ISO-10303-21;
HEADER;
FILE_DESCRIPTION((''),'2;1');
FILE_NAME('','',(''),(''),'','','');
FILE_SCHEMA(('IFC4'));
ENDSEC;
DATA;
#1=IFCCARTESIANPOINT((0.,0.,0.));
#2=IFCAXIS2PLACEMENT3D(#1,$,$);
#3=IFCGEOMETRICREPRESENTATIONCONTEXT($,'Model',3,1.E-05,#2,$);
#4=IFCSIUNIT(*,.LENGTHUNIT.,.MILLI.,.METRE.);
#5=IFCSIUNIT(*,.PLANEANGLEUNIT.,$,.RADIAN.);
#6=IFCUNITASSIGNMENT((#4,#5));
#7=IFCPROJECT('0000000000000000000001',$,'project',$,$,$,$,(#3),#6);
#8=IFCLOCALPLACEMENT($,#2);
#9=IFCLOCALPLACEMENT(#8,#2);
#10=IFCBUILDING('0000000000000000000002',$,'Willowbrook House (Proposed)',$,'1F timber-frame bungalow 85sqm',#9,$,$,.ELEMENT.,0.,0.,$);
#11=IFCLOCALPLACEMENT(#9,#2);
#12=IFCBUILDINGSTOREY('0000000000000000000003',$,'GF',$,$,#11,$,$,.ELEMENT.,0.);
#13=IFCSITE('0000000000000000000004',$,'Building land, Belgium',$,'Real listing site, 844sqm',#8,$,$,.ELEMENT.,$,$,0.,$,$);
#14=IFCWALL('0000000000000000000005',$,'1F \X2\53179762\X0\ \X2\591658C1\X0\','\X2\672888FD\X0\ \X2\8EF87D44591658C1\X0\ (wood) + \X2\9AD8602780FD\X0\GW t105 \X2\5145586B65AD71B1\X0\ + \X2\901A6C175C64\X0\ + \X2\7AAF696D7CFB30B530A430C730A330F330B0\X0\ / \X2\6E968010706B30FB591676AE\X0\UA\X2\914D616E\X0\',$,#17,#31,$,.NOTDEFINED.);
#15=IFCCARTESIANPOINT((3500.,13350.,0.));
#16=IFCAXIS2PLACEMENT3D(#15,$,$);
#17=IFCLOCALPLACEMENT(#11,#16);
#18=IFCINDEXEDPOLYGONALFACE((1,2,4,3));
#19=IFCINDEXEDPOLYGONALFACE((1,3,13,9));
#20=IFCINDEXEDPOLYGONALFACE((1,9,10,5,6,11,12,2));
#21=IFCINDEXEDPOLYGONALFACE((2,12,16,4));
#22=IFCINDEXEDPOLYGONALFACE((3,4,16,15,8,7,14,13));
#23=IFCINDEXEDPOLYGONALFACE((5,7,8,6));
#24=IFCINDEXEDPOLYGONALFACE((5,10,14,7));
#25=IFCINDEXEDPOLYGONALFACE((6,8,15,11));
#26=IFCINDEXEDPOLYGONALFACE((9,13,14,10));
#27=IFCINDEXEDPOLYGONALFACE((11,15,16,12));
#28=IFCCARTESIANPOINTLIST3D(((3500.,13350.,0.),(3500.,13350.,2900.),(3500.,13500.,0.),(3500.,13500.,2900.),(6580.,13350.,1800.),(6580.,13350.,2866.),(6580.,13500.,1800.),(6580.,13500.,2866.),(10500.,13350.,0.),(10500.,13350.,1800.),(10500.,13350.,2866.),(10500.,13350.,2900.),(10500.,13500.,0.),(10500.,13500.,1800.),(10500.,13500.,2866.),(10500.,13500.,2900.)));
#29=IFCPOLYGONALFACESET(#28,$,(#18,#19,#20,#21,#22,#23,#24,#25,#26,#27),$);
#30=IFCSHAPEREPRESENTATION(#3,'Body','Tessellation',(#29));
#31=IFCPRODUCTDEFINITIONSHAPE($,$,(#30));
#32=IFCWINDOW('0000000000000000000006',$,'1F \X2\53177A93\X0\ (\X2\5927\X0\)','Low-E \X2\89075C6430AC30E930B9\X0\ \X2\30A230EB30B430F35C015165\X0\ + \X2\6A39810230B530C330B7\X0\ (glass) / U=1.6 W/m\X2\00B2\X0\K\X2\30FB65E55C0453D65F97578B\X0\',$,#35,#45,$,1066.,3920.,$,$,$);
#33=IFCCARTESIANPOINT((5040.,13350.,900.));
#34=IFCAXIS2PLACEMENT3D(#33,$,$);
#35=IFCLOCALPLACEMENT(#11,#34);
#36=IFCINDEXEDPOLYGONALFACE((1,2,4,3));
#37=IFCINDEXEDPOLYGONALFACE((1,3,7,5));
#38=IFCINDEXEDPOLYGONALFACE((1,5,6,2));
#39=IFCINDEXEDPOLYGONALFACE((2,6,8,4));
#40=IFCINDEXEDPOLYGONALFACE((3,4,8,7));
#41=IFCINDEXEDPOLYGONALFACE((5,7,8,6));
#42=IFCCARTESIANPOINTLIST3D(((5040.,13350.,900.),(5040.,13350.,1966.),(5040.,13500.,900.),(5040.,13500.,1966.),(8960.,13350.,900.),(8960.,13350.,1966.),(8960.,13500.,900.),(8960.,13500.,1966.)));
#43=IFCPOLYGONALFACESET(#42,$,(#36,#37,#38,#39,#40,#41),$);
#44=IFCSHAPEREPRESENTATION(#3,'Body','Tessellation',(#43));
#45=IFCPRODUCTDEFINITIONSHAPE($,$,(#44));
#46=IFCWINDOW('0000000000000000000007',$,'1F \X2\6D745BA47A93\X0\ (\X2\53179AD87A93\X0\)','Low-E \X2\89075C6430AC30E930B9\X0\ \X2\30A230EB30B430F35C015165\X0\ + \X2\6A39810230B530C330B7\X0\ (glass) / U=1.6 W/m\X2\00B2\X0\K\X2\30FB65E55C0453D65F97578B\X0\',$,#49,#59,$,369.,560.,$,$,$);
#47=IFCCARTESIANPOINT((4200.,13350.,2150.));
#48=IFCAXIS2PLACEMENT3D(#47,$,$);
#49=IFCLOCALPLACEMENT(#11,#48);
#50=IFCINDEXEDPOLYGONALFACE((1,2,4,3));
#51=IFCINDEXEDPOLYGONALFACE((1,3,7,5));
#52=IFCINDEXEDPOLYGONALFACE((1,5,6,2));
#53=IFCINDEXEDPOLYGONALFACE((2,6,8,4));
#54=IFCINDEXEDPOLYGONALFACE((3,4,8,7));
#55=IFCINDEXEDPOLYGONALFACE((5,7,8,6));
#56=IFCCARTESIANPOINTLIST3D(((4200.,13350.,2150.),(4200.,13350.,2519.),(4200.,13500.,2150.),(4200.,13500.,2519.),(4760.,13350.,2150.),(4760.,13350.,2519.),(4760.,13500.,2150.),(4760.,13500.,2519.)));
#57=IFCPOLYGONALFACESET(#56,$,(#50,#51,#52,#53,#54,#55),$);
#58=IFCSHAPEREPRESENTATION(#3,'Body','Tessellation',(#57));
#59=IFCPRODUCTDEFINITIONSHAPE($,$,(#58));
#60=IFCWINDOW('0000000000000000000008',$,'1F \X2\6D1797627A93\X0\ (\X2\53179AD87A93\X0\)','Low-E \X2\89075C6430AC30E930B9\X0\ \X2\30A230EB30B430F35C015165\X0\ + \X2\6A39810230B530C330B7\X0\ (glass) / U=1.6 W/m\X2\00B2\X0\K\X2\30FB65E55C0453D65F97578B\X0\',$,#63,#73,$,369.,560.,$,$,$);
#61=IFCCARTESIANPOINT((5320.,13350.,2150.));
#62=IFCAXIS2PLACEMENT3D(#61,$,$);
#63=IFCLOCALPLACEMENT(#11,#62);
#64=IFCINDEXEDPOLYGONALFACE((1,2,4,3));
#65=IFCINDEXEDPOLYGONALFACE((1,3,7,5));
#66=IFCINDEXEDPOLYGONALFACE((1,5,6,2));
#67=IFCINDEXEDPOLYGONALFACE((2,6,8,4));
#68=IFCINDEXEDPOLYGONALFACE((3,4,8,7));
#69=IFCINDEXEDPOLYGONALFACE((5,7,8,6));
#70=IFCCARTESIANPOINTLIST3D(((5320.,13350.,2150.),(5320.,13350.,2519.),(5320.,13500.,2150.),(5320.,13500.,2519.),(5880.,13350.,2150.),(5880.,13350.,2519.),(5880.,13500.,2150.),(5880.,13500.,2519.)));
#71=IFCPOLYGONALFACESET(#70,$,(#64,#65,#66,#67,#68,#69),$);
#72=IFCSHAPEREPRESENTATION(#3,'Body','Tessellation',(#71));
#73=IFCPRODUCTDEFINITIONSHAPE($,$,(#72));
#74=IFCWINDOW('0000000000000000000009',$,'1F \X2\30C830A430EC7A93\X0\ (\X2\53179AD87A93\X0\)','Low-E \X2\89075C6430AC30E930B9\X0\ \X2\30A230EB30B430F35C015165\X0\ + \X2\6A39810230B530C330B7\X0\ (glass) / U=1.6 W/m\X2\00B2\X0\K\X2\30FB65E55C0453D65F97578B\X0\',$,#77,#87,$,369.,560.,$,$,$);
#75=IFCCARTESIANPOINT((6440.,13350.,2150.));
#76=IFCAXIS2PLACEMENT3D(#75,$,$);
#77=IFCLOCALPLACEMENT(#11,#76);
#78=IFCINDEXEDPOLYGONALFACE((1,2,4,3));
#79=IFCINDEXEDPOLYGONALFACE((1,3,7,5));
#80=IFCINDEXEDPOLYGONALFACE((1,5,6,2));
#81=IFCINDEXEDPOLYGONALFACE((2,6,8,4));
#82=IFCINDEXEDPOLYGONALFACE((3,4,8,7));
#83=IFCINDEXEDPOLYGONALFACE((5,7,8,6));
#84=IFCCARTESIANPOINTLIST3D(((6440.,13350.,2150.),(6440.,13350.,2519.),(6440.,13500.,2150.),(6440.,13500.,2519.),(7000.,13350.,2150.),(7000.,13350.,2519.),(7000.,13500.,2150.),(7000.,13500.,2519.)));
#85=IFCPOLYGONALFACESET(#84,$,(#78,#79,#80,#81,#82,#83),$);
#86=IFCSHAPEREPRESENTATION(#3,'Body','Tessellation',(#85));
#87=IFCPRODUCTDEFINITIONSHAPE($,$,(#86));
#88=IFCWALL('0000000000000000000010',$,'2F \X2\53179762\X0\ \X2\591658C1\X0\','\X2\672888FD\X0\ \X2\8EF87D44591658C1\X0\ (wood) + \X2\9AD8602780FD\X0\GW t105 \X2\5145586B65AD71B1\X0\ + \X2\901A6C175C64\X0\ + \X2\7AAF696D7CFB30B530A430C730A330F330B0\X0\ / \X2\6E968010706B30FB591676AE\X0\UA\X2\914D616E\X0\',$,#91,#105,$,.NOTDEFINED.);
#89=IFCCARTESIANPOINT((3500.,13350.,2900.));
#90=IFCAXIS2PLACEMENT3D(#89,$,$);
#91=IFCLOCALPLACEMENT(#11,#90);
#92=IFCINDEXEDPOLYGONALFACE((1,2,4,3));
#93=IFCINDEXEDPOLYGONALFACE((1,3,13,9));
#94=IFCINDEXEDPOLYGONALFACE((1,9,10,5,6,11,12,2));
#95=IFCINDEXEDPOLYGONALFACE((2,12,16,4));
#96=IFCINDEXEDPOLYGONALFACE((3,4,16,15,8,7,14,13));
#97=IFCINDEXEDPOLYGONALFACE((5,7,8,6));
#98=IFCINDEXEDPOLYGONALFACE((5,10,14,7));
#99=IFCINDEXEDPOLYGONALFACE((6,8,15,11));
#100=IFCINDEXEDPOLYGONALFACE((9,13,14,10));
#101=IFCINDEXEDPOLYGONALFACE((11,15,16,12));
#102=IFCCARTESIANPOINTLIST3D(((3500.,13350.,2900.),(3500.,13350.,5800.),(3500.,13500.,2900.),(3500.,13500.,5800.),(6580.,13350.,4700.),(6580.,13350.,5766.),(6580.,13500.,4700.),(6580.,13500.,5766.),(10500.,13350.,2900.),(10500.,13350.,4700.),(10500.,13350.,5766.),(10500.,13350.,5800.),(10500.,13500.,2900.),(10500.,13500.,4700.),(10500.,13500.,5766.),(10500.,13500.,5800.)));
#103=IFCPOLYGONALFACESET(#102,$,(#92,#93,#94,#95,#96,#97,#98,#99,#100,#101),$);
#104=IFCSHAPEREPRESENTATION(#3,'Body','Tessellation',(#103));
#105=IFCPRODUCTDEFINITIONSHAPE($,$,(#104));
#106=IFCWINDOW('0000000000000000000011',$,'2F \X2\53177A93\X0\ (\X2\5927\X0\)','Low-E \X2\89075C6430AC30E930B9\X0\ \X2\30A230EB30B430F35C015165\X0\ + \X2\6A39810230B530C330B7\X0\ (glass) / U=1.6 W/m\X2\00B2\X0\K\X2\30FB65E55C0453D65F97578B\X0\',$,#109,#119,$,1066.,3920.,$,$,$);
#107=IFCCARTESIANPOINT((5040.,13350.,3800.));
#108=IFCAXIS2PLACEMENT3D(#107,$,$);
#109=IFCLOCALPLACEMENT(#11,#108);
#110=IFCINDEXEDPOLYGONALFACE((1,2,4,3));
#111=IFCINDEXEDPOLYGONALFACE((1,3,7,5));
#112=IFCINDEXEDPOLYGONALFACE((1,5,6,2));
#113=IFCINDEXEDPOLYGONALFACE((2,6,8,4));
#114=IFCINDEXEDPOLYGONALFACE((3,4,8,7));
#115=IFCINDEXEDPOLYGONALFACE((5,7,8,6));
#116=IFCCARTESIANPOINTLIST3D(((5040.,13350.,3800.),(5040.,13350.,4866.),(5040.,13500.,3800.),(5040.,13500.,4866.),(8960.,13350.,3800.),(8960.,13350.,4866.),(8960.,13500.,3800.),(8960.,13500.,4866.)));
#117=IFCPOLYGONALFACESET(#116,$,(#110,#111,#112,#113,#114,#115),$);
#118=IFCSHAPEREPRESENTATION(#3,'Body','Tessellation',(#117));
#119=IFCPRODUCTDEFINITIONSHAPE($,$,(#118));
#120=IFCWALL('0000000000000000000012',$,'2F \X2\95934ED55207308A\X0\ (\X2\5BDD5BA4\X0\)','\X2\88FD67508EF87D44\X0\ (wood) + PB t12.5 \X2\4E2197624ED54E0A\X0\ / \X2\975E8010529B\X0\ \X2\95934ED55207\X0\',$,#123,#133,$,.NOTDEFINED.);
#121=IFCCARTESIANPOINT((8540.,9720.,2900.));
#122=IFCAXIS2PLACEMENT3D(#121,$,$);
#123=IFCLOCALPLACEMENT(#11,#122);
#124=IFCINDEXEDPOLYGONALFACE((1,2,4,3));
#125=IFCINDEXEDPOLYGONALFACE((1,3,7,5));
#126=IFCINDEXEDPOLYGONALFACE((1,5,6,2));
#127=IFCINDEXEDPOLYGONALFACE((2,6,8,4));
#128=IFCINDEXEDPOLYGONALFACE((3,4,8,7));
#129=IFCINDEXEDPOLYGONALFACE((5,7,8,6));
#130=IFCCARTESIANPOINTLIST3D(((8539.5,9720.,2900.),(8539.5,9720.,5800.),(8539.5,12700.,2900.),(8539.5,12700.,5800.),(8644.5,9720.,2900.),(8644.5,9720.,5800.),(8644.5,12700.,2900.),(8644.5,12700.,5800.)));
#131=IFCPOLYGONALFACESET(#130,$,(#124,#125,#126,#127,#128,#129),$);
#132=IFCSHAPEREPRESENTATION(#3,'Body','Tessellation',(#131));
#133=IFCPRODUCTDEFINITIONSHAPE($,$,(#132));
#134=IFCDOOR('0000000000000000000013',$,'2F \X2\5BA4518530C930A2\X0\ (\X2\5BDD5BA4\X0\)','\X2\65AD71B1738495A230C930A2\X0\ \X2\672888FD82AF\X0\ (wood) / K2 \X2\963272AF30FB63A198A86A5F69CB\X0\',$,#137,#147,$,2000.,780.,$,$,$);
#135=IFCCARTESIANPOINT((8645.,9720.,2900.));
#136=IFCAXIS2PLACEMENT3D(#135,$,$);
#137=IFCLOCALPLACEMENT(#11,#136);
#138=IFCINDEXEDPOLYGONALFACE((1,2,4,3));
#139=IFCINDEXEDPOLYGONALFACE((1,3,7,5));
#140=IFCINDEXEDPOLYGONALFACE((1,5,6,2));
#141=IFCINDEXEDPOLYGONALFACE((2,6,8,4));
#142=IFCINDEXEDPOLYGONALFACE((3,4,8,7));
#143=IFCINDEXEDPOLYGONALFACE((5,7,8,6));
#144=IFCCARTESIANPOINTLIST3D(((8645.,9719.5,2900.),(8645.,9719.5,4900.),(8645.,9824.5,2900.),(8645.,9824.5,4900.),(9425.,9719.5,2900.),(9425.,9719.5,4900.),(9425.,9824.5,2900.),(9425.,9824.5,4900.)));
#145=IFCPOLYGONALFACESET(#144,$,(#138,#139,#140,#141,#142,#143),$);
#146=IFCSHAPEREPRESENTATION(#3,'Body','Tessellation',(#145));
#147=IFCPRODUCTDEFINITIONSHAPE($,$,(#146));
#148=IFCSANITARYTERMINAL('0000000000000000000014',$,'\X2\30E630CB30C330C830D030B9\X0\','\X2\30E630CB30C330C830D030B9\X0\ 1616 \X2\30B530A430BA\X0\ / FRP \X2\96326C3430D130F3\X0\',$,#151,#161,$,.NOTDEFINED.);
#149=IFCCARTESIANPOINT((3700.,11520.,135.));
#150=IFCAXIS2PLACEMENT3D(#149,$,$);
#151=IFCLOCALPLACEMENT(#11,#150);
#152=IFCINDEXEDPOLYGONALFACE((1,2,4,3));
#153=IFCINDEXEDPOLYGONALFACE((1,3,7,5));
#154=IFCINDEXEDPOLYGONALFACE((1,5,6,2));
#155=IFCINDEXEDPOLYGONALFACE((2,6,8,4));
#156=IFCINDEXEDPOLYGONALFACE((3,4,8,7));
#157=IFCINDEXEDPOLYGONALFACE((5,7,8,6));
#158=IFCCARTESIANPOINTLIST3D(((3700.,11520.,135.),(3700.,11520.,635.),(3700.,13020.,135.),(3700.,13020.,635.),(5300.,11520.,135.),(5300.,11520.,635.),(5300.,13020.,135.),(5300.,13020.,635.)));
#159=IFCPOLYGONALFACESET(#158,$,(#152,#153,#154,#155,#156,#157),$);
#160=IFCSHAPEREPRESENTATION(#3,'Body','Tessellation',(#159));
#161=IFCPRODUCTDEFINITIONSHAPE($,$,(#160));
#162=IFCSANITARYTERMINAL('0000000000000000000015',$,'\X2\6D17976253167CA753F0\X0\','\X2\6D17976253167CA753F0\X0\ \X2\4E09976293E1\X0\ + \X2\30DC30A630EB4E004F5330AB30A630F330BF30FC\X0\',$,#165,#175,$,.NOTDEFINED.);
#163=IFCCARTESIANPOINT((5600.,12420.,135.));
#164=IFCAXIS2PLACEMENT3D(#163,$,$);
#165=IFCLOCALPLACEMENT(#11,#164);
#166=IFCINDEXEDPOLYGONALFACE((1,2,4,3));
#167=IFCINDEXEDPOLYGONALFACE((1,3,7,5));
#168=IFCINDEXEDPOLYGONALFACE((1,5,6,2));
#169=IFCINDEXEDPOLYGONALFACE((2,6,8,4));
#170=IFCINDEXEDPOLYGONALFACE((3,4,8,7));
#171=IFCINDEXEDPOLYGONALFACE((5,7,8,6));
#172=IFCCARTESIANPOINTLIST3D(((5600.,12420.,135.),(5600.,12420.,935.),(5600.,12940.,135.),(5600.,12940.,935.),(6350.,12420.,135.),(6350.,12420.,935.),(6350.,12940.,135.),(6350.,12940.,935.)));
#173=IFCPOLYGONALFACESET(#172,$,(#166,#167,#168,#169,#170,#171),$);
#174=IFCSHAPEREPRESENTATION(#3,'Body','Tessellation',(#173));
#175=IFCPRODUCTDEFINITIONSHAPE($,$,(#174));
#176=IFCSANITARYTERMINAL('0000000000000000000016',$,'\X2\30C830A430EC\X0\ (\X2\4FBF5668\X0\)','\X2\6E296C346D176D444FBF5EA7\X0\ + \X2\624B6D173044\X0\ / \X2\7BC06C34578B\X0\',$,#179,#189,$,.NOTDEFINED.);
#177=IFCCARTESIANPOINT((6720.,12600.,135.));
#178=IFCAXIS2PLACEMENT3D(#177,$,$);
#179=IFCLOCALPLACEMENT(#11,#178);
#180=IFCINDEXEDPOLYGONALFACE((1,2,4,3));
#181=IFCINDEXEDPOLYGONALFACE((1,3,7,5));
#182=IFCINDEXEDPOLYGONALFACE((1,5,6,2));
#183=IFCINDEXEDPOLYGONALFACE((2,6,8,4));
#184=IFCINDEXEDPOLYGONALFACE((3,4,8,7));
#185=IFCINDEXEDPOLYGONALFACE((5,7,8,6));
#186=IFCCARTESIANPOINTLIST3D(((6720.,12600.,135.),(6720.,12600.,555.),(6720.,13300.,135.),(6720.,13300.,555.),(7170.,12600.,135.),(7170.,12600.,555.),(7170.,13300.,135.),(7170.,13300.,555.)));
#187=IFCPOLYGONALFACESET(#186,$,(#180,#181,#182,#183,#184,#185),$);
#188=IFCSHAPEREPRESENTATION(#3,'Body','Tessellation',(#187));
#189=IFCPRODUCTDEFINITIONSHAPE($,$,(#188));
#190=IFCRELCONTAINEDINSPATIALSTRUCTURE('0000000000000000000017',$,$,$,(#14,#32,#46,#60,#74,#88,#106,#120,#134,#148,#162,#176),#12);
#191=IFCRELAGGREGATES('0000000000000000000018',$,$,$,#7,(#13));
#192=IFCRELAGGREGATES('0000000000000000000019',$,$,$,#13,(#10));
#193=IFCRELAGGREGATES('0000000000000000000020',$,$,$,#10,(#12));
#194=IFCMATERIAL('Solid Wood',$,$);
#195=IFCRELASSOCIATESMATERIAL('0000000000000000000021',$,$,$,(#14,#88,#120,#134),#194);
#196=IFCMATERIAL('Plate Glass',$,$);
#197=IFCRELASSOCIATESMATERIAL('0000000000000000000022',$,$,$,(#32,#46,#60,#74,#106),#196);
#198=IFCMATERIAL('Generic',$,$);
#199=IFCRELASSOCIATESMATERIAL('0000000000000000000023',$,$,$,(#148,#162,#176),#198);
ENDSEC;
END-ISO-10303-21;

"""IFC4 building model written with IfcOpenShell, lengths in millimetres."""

from ifc_helpers import new_model, si_unit, frame, frame_2d, origin, place, context, project, spatial, rectangle, extrude, material, element, fill, save


model = new_model("IFC4")

# Units and contexts
model_context = context("Model", 3, precision=1e-05, world=origin())
ifc_project = project(units=[si_unit("LENGTHUNIT", "METRE", prefix="MILLI"), si_unit("PLANEANGLEUNIT", "RADIAN")], contexts=[model_context])

# Site, building, storey
site_placement = place(None, origin())
site = spatial("IfcSite", under=ifc_project, at=site_placement, Name="Building land, Belgium", ObjectType="Real listing site, 844sqm", CompositionType="ELEMENT", RefElevation=0.0)
building_placement = place(site_placement, origin())
building = spatial("IfcBuilding", under=site, at=building_placement, Name="Willowbrook House (Proposed)", ObjectType="1F timber-frame bungalow 85sqm", CompositionType="ELEMENT", ElevationOfRefHeight=0.0, ElevationOfTerrain=0.0)
storey_placement = place(building_placement, origin())
storey = spatial("IfcBuildingStorey", under=building, at=storey_placement, Name="GF", CompositionType="ELEMENT", Elevation=0.0)

# Wall, openings, windows
ifc_material_1 = material(Name="Solid Wood")
wall_1_placement = place(storey_placement, frame((3500.0, 13350.0, 0.0)))
wall_1 = element("IfcWall", 1, at=wall_1_placement, inside=storey, material=ifc_material_1, Name="1F 北面 外壁", Description="木製 軸組外壁 (wood) + 高性能GW t105 充填断熱 + 通気層 + 窯業系サイディング / 準耐火・外皮UA配慮", PredefinedType="NOTDEFINED", context=model_context, shape_type="SweptSolid", body=[
    extrude(rectangle(XDim=7000.0, YDim=150.0, at=frame_2d((3500.0, 75.0))), frame((3500.0, 13350.0, 0.0)), (0.0, 0.0, 1.0), 2900.0),
])
opening_1_placement = place(storey_placement, frame((5040.0, 13350.0, 900.0)))
opening_1 = element("IfcOpeningElement", 2, at=opening_1_placement, cuts=wall_1, PredefinedType="NOTDEFINED", context=model_context, shape_type="SweptSolid", body=[
    extrude(rectangle(XDim=3920.0, YDim=150.0, at=frame_2d((1960.0, 75.0))), frame((5040.0, 13350.0, 900.0)), (0.0, 0.0, 1.0), 1066.0),
])
opening_2_placement = place(storey_placement, frame((4200.0, 13350.0, 2150.0)))
opening_2 = element("IfcOpeningElement", 3, at=opening_2_placement, cuts=wall_1, PredefinedType="NOTDEFINED", context=model_context, shape_type="SweptSolid", body=[
    extrude(rectangle(XDim=560.0, YDim=150.0, at=frame_2d((280.0, 75.0))), frame((4200.0, 13350.0, 2150.0)), (0.0, 0.0, 1.0), 369.0),
])
opening_3_placement = place(storey_placement, frame((5320.0, 13350.0, 2150.0)))
opening_3 = element("IfcOpeningElement", 4, at=opening_3_placement, cuts=wall_1, PredefinedType="NOTDEFINED", context=model_context, shape_type="SweptSolid", body=[
    extrude(rectangle(XDim=560.0, YDim=150.0, at=frame_2d((280.0, 75.0))), frame((5320.0, 13350.0, 2150.0)), (0.0, 0.0, 1.0), 369.0),
])
opening_4_placement = place(storey_placement, frame((6440.0, 13350.0, 2150.0)))
opening_4 = element("IfcOpeningElement", 5, at=opening_4_placement, cuts=wall_1, PredefinedType="NOTDEFINED", context=model_context, shape_type="SweptSolid", body=[
    extrude(rectangle(XDim=560.0, YDim=150.0, at=frame_2d((280.0, 75.0))), frame((6440.0, 13350.0, 2150.0)), (0.0, 0.0, 1.0), 369.0),
])
ifc_material_2 = material(Name="Plate Glass")
window_1_placement = place(storey_placement, frame((5040.0, 13350.0, 900.0)))
window_1 = element("IfcWindow", 6, at=window_1_placement, inside=storey, material=ifc_material_2, Name="1F 北窓 (大)", Description="Low-E 複層ガラス アルゴン封入 + 樹脂サッシ (glass) / U=1.6 W/m²K・日射取得型", OverallHeight=1066.0, OverallWidth=3920.0, context=model_context, shape_type="SweptSolid", body=[
    extrude(rectangle(XDim=3920.0, YDim=150.0, at=frame_2d((1960.0, 75.0))), frame((5040.0, 13350.0, 900.0)), (0.0, 0.0, 1.0), 1066.0),
])
fill(opening_1, window_1)
window_2_placement = place(storey_placement, frame((4200.0, 13350.0, 2150.0)))
window_2 = element("IfcWindow", 7, at=window_2_placement, inside=storey, material=ifc_material_2, Name="1F 浴室窓 (北高窓)", Description="Low-E 複層ガラス アルゴン封入 + 樹脂サッシ (glass) / U=1.6 W/m²K・日射取得型", OverallHeight=369.0, OverallWidth=560.0, context=model_context, shape_type="SweptSolid", body=[
    extrude(rectangle(XDim=560.0, YDim=150.0, at=frame_2d((280.0, 75.0))), frame((4200.0, 13350.0, 2150.0)), (0.0, 0.0, 1.0), 369.0),
])
fill(opening_2, window_2)
window_3_placement = place(storey_placement, frame((5320.0, 13350.0, 2150.0)))
window_3 = element("IfcWindow", 8, at=window_3_placement, inside=storey, material=ifc_material_2, Name="1F 洗面窓 (北高窓)", Description="Low-E 複層ガラス アルゴン封入 + 樹脂サッシ (glass) / U=1.6 W/m²K・日射取得型", OverallHeight=369.0, OverallWidth=560.0, context=model_context, shape_type="SweptSolid", body=[
    extrude(rectangle(XDim=560.0, YDim=150.0, at=frame_2d((280.0, 75.0))), frame((5320.0, 13350.0, 2150.0)), (0.0, 0.0, 1.0), 369.0),
])
fill(opening_3, window_3)
window_4_placement = place(storey_placement, frame((6440.0, 13350.0, 2150.0)))
window_4 = element("IfcWindow", 9, at=window_4_placement, inside=storey, material=ifc_material_2, Name="1F トイレ窓 (北高窓)", Description="Low-E 複層ガラス アルゴン封入 + 樹脂サッシ (glass) / U=1.6 W/m²K・日射取得型", OverallHeight=369.0, OverallWidth=560.0, context=model_context, shape_type="SweptSolid", body=[
    extrude(rectangle(XDim=560.0, YDim=150.0, at=frame_2d((280.0, 75.0))), frame((6440.0, 13350.0, 2150.0)), (0.0, 0.0, 1.0), 369.0),
])
fill(opening_4, window_4)

# Wall, opening, window
wall_2_placement = place(storey_placement, frame((3500.0, 13350.0, 2900.0)))
wall_2 = element("IfcWall", 10, at=wall_2_placement, inside=storey, material=ifc_material_1, Name="2F 北面 外壁", Description="木製 軸組外壁 (wood) + 高性能GW t105 充填断熱 + 通気層 + 窯業系サイディング / 準耐火・外皮UA配慮", PredefinedType="NOTDEFINED", context=model_context, shape_type="SweptSolid", body=[
    extrude(rectangle(XDim=7000.0, YDim=150.0, at=frame_2d((3500.0, 75.0))), frame((3500.0, 13350.0, 2900.0)), (0.0, 0.0, 1.0), 2900.0),
])
opening_5_placement = place(storey_placement, frame((5040.0, 13350.0, 3800.0)))
opening_5 = element("IfcOpeningElement", 11, at=opening_5_placement, cuts=wall_2, PredefinedType="NOTDEFINED", context=model_context, shape_type="SweptSolid", body=[
    extrude(rectangle(XDim=3920.0, YDim=150.0, at=frame_2d((1960.0, 75.0))), frame((5040.0, 13350.0, 3800.0)), (0.0, 0.0, 1.0), 1066.0),
])
window_5_placement = place(storey_placement, frame((5040.0, 13350.0, 3800.0)))
window_5 = element("IfcWindow", 12, at=window_5_placement, inside=storey, material=ifc_material_2, Name="2F 北窓 (大)", Description="Low-E 複層ガラス アルゴン封入 + 樹脂サッシ (glass) / U=1.6 W/m²K・日射取得型", OverallHeight=1066.0, OverallWidth=3920.0, context=model_context, shape_type="SweptSolid", body=[
    extrude(rectangle(XDim=3920.0, YDim=150.0, at=frame_2d((1960.0, 75.0))), frame((5040.0, 13350.0, 3800.0)), (0.0, 0.0, 1.0), 1066.0),
])
fill(opening_5, window_5)

# Wall
wall_3_placement = place(storey_placement, frame((8540.0, 9720.0, 2900.0)))
element("IfcWall", 13, at=wall_3_placement, inside=storey, material=ifc_material_1, Name="2F 間仕切り (寝室)", Description="製材軸組 (wood) + PB t12.5 両面仕上 / 非耐力 間仕切", PredefinedType="NOTDEFINED", context=model_context, shape_type="SweptSolid", body=[
    extrude(rectangle(XDim=105.0, YDim=2980.0, at=frame_2d((52.0, 1490.0))), frame((8540.0, 9720.0, 2900.0)), (0.0, 0.0, 1.0), 2900.0),
])

# Door
door_1_placement = place(storey_placement, frame((8645.0, 9720.0, 2900.0)))
element("IfcDoor", 14, at=door_1_placement, inside=storey, material=ifc_material_1, Name="2F 室内ドア (寝室)", Description="断熱玄関ドア 木製芯 (wood) / K2 防犯・採風機構", OverallHeight=2000.0, OverallWidth=780.0, context=model_context, shape_type="SweptSolid", body=[
    extrude(rectangle(XDim=780.0, YDim=105.0, at=frame_2d((390.0, 52.0))), frame((8645.0, 9720.0, 2900.0)), (0.0, 0.0, 1.0), 2000.0),
])

# Sanitary terminals
ifc_material_3 = material(Name="Generic")
sanitary_terminal_1_placement = place(storey_placement, frame((3700.0, 11520.0, 135.0)))
element("IfcSanitaryTerminal", 15, at=sanitary_terminal_1_placement, inside=storey, material=ifc_material_3, Name="ユニットバス", Description="ユニットバス 1616 サイズ / FRP 防水パン", PredefinedType="NOTDEFINED", context=model_context, shape_type="SweptSolid", body=[
    extrude(rectangle(XDim=1600.0, YDim=1500.0, at=frame_2d((800.0, 750.0))), frame((3700.0, 11520.0, 135.0)), (0.0, 0.0, 1.0), 500.0),
])
sanitary_terminal_2_placement = place(storey_placement, frame((5600.0, 12420.0, 135.0)))
element("IfcSanitaryTerminal", 16, at=sanitary_terminal_2_placement, inside=storey, material=ifc_material_3, Name="洗面化粧台", Description="洗面化粧台 三面鏡 + ボウル一体カウンター", PredefinedType="NOTDEFINED", context=model_context, shape_type="SweptSolid", body=[
    extrude(rectangle(XDim=750.0, YDim=520.0, at=frame_2d((375.0, 260.0))), frame((5600.0, 12420.0, 135.0)), (0.0, 0.0, 1.0), 800.0),
])
sanitary_terminal_3_placement = place(storey_placement, frame((6720.0, 12600.0, 135.0)))
element("IfcSanitaryTerminal", 17, at=sanitary_terminal_3_placement, inside=storey, material=ifc_material_3, Name="トイレ (便器)", Description="温水洗浄便座 + 手洗い / 節水型", PredefinedType="NOTDEFINED", context=model_context, shape_type="SweptSolid", body=[
    extrude(rectangle(XDim=450.0, YDim=700.0, at=frame_2d((225.0, 350.0))), frame((6720.0, 12600.0, 135.0)), (0.0, 0.0, 1.0), 420.0),
])

save(model, "model.ifc")
